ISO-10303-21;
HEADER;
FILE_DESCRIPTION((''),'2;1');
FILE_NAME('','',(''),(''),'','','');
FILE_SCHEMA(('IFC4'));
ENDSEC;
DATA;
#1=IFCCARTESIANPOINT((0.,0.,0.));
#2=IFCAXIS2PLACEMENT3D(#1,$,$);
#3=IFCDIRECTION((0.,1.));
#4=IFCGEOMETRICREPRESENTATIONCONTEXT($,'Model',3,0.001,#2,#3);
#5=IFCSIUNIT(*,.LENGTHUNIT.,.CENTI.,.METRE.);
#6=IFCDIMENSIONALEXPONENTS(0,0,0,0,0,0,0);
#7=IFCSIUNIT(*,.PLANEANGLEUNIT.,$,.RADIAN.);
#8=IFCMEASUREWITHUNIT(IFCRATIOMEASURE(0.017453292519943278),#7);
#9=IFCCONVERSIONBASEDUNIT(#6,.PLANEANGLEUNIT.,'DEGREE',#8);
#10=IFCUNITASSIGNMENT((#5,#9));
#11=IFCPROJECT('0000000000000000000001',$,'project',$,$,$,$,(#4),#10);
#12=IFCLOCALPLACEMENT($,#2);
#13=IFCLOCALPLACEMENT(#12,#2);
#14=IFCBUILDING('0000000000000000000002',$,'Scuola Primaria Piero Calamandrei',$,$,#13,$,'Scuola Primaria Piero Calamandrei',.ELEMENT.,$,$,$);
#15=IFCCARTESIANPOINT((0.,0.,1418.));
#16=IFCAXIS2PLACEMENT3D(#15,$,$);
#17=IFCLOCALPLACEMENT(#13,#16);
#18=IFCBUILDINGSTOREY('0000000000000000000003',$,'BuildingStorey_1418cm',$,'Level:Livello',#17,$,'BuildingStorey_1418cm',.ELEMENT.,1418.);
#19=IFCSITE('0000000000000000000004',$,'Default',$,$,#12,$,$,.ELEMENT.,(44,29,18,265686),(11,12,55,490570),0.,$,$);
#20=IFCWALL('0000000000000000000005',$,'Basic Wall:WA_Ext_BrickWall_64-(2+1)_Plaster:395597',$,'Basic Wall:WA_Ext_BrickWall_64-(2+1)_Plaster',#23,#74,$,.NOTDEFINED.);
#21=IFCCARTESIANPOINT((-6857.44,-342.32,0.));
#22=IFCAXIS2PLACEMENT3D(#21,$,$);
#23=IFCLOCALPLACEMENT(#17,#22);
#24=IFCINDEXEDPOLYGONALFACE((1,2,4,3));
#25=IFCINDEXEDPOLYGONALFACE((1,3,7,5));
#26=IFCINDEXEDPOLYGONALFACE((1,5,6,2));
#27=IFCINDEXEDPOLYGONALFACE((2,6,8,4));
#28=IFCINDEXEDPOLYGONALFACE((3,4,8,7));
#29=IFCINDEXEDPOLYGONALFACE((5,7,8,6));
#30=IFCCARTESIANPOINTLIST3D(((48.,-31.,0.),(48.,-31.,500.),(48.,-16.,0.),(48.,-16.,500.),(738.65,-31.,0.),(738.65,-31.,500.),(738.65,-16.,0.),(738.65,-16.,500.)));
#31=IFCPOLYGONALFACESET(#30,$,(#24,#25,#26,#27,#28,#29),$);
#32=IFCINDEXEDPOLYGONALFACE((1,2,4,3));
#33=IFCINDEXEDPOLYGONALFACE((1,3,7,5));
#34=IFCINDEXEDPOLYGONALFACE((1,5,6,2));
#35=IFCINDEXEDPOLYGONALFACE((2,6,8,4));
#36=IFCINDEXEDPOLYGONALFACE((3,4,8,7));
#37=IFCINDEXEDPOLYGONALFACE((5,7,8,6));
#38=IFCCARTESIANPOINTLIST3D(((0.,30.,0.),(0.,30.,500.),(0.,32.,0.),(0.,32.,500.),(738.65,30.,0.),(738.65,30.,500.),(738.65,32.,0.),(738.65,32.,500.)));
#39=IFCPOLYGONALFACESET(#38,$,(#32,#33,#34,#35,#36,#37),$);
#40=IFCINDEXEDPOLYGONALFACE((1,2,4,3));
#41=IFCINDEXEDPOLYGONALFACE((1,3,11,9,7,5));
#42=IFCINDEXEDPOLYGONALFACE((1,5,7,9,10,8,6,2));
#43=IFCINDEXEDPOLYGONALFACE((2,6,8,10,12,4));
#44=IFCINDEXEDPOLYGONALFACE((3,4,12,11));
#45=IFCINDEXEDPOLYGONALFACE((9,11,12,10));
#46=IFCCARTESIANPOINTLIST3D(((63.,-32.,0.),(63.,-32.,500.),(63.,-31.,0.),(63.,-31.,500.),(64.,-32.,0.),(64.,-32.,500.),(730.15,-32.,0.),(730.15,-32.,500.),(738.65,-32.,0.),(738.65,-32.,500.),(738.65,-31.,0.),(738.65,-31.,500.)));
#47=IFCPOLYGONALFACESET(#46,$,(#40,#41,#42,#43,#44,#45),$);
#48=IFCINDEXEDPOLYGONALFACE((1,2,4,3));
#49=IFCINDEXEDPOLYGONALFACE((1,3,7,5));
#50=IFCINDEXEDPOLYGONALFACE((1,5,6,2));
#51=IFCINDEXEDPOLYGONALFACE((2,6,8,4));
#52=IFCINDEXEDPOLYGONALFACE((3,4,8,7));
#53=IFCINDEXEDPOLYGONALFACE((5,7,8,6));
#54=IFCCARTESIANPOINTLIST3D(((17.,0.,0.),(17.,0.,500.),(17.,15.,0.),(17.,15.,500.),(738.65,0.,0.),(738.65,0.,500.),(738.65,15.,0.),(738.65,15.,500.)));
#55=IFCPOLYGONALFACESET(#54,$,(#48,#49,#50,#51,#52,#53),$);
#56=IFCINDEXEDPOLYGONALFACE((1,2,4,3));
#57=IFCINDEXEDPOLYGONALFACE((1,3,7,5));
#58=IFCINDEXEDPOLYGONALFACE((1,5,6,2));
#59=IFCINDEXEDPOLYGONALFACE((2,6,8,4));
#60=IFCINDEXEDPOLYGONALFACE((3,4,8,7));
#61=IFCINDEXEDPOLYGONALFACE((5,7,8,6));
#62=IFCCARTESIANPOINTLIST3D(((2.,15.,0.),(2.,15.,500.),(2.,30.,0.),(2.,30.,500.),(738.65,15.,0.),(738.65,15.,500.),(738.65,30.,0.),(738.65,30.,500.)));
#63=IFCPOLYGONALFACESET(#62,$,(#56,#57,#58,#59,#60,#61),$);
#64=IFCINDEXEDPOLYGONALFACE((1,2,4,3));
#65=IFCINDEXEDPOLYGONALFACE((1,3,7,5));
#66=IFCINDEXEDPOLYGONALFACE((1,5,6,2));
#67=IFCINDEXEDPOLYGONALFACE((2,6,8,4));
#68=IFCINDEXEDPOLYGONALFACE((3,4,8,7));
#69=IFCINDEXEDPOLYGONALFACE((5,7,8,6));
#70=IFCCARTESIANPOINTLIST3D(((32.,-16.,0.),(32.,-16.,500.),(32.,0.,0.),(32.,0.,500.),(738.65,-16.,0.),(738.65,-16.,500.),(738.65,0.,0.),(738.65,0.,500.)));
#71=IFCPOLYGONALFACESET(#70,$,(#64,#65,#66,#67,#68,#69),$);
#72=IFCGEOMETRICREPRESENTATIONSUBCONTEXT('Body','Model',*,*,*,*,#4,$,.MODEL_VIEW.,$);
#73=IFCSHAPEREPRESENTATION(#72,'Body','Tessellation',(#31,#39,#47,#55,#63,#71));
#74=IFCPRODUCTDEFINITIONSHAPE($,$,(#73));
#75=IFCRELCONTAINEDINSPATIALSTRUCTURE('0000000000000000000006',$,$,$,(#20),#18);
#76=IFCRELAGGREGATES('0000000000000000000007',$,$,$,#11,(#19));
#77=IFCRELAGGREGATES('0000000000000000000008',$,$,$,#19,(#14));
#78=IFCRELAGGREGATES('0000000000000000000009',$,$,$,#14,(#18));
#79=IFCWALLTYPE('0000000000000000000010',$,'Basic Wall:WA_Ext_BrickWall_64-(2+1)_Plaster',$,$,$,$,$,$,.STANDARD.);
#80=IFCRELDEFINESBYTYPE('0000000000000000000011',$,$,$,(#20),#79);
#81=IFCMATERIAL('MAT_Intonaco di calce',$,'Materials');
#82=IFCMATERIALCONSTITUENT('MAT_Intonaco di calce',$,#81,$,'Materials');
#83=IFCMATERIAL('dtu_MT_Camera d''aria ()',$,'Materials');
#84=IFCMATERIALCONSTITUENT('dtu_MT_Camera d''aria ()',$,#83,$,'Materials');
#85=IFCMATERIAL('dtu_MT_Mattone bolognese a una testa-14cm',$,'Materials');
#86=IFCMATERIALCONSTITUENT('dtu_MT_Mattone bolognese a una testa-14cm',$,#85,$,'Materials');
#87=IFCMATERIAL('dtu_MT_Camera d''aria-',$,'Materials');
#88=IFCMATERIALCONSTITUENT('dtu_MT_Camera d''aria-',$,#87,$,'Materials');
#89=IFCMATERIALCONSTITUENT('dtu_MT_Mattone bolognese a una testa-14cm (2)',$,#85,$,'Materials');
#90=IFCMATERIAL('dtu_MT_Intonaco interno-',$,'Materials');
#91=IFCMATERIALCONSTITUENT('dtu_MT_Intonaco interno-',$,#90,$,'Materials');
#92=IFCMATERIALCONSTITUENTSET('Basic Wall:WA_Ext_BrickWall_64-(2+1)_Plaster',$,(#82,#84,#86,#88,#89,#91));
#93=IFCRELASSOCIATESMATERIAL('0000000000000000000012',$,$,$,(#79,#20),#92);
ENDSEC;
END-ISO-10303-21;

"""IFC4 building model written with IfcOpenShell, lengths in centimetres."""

from ifc_helpers import new_model, entity, si_unit, converted_unit, direction, frame, origin, place, context, subcontext, project, spatial, indexed_curve, outline, extrude, material, constituent, constituent_set, type_object, element, save


model = new_model("IFC4")

# Units and contexts
model_context = context("Model", 3, precision=0.001, world=origin(), true_north=direction((0.0, 1.0)))
body_context = subcontext(model_context, "Body", "Model", "MODEL_VIEW")
ifc_project = project(units=[si_unit("LENGTHUNIT", "METRE", prefix="CENTI"), converted_unit("PLANEANGLEUNIT", "DEGREE", entity("IfcRatioMeasure", 0.017453292519943278), si_unit("PLANEANGLEUNIT", "RADIAN"), dimensions=[0, 0, 0, 0, 0, 0, 0])], contexts=[model_context])

# Site, building, storey
site_placement = place(None, origin())
site = spatial("IfcSite", under=ifc_project, at=site_placement, Name="Default", CompositionType="ELEMENT", RefLatitude=(44, 29, 18, 265686), RefLongitude=(11, 12, 55, 490570), RefElevation=0.0)
building_placement = place(site_placement, origin())
building = spatial("IfcBuilding", under=site, at=building_placement, Name="Scuola Primaria Piero Calamandrei", LongName="Scuola Primaria Piero Calamandrei", CompositionType="ELEMENT")
storey_placement = place(building_placement, frame((0.0, 0.0, 1418.0)))
storey = spatial("IfcBuildingStorey", under=building, at=storey_placement, Name="BuildingStorey_1418cm", ObjectType="Level:Livello", LongName="BuildingStorey_1418cm", CompositionType="ELEMENT", Elevation=1418.0)

# Shared definitions
ifc_material_1 = material(Name="MAT_Intonaco di calce", Category="Materials")
ifc_constituent_1 = constituent(ifc_material_1, Name="MAT_Intonaco di calce", Category="Materials")
ifc_material_2 = material(Name="dtu_MT_Camera d'aria ()", Category="Materials")
ifc_constituent_2 = constituent(ifc_material_2, Name="dtu_MT_Camera d'aria ()", Category="Materials")
ifc_material_3 = material(Name="dtu_MT_Mattone bolognese a una testa-14cm", Category="Materials")
ifc_constituent_3 = constituent(ifc_material_3, Name="dtu_MT_Mattone bolognese a una testa-14cm", Category="Materials")
ifc_material_4 = material(Name="dtu_MT_Camera d'aria-", Category="Materials")
ifc_constituent_4 = constituent(ifc_material_4, Name="dtu_MT_Camera d'aria-", Category="Materials")
ifc_constituent_5 = constituent(ifc_material_3, Name="dtu_MT_Mattone bolognese a una testa-14cm (2)", Category="Materials")
ifc_material_5 = material(Name="dtu_MT_Intonaco interno-", Category="Materials")
ifc_constituent_6 = constituent(ifc_material_5, Name="dtu_MT_Intonaco interno-", Category="Materials")
ifc_constituent_set_1 = constituent_set(constituents=[ifc_constituent_1, ifc_constituent_2, ifc_constituent_3, ifc_constituent_4, ifc_constituent_5, ifc_constituent_6], Name="Basic Wall:WA_Ext_BrickWall_64-(2+1)_Plaster")
wall_type_1 = type_object("IfcWallType", Name="Basic Wall:WA_Ext_BrickWall_64-(2+1)_Plaster", PredefinedType="STANDARD", material=ifc_constituent_set_1)

# Wall
wall_1_placement = place(storey_placement, frame((-6857.44, -342.32, 0.0)))
element("IfcWall", 1, at=wall_1_placement, inside=storey, type_object=wall_type_1, material=ifc_constituent_set_1, Name="Basic Wall:WA_Ext_BrickWall_64-(2+1)_Plaster:395597", ObjectType="Basic Wall:WA_Ext_BrickWall_64-(2+1)_Plaster", PredefinedType="NOTDEFINED", context=body_context, shape_type="SweptSolid", body=[
    extrude(outline(indexed_curve([(-345.33, -7.5), (345.33, -7.5), (345.33, 7.5), (-345.33, 7.5), (-345.33, -7.5)], self_intersect=False)), frame((393.33, -23.5, 0.0)), (0.0, 0.0, 1.0), 500.0),
    extrude(outline(indexed_curve([(-1.0, -369.33), (1.0, -369.33), (1.0, 369.33), (-1.0, 369.33), (-1.0, -369.33)], self_intersect=False)), frame((369.33, 31.0, 0.0), z_axis=(0.0, 0.0, 1.0), x_axis=(0.0, -1.0, 0.0)), (0.0, 0.0, 1.0), 500.0),
    extrude(outline(indexed_curve([(-335.58, -0.33), (330.58, -0.33), (339.08, -0.33), (339.08, 0.67), (-336.58, 0.67), (-336.58, -0.33), (-335.58, -0.33)], self_intersect=False)), frame((399.58, -31.67, 0.0)), (0.0, 0.0, 1.0), 500.0),
    extrude(outline(indexed_curve([(-360.83, -7.5), (360.83, -7.5), (360.83, 7.5), (-360.83, 7.5), (-360.83, -7.5)], self_intersect=False)), frame((377.83, 7.5, 0.0)), (0.0, 0.0, 1.0), 500.0),
    extrude(outline(indexed_curve([(-368.33, -7.5), (368.33, -7.5), (368.33, 7.5), (-368.33, 7.5), (-368.33, -7.5)], self_intersect=False)), frame((370.33, 22.5, 0.0)), (0.0, 0.0, 1.0), 500.0),
    extrude(outline(indexed_curve([(-353.33, -8.0), (353.33, -8.0), (353.33, 8.0), (-353.33, 8.0), (-353.33, -8.0)], self_intersect=False)), frame((385.33, -8.0, 0.0)), (0.0, 0.0, 1.0), 500.0),
])

save(model, "model.ifc")
